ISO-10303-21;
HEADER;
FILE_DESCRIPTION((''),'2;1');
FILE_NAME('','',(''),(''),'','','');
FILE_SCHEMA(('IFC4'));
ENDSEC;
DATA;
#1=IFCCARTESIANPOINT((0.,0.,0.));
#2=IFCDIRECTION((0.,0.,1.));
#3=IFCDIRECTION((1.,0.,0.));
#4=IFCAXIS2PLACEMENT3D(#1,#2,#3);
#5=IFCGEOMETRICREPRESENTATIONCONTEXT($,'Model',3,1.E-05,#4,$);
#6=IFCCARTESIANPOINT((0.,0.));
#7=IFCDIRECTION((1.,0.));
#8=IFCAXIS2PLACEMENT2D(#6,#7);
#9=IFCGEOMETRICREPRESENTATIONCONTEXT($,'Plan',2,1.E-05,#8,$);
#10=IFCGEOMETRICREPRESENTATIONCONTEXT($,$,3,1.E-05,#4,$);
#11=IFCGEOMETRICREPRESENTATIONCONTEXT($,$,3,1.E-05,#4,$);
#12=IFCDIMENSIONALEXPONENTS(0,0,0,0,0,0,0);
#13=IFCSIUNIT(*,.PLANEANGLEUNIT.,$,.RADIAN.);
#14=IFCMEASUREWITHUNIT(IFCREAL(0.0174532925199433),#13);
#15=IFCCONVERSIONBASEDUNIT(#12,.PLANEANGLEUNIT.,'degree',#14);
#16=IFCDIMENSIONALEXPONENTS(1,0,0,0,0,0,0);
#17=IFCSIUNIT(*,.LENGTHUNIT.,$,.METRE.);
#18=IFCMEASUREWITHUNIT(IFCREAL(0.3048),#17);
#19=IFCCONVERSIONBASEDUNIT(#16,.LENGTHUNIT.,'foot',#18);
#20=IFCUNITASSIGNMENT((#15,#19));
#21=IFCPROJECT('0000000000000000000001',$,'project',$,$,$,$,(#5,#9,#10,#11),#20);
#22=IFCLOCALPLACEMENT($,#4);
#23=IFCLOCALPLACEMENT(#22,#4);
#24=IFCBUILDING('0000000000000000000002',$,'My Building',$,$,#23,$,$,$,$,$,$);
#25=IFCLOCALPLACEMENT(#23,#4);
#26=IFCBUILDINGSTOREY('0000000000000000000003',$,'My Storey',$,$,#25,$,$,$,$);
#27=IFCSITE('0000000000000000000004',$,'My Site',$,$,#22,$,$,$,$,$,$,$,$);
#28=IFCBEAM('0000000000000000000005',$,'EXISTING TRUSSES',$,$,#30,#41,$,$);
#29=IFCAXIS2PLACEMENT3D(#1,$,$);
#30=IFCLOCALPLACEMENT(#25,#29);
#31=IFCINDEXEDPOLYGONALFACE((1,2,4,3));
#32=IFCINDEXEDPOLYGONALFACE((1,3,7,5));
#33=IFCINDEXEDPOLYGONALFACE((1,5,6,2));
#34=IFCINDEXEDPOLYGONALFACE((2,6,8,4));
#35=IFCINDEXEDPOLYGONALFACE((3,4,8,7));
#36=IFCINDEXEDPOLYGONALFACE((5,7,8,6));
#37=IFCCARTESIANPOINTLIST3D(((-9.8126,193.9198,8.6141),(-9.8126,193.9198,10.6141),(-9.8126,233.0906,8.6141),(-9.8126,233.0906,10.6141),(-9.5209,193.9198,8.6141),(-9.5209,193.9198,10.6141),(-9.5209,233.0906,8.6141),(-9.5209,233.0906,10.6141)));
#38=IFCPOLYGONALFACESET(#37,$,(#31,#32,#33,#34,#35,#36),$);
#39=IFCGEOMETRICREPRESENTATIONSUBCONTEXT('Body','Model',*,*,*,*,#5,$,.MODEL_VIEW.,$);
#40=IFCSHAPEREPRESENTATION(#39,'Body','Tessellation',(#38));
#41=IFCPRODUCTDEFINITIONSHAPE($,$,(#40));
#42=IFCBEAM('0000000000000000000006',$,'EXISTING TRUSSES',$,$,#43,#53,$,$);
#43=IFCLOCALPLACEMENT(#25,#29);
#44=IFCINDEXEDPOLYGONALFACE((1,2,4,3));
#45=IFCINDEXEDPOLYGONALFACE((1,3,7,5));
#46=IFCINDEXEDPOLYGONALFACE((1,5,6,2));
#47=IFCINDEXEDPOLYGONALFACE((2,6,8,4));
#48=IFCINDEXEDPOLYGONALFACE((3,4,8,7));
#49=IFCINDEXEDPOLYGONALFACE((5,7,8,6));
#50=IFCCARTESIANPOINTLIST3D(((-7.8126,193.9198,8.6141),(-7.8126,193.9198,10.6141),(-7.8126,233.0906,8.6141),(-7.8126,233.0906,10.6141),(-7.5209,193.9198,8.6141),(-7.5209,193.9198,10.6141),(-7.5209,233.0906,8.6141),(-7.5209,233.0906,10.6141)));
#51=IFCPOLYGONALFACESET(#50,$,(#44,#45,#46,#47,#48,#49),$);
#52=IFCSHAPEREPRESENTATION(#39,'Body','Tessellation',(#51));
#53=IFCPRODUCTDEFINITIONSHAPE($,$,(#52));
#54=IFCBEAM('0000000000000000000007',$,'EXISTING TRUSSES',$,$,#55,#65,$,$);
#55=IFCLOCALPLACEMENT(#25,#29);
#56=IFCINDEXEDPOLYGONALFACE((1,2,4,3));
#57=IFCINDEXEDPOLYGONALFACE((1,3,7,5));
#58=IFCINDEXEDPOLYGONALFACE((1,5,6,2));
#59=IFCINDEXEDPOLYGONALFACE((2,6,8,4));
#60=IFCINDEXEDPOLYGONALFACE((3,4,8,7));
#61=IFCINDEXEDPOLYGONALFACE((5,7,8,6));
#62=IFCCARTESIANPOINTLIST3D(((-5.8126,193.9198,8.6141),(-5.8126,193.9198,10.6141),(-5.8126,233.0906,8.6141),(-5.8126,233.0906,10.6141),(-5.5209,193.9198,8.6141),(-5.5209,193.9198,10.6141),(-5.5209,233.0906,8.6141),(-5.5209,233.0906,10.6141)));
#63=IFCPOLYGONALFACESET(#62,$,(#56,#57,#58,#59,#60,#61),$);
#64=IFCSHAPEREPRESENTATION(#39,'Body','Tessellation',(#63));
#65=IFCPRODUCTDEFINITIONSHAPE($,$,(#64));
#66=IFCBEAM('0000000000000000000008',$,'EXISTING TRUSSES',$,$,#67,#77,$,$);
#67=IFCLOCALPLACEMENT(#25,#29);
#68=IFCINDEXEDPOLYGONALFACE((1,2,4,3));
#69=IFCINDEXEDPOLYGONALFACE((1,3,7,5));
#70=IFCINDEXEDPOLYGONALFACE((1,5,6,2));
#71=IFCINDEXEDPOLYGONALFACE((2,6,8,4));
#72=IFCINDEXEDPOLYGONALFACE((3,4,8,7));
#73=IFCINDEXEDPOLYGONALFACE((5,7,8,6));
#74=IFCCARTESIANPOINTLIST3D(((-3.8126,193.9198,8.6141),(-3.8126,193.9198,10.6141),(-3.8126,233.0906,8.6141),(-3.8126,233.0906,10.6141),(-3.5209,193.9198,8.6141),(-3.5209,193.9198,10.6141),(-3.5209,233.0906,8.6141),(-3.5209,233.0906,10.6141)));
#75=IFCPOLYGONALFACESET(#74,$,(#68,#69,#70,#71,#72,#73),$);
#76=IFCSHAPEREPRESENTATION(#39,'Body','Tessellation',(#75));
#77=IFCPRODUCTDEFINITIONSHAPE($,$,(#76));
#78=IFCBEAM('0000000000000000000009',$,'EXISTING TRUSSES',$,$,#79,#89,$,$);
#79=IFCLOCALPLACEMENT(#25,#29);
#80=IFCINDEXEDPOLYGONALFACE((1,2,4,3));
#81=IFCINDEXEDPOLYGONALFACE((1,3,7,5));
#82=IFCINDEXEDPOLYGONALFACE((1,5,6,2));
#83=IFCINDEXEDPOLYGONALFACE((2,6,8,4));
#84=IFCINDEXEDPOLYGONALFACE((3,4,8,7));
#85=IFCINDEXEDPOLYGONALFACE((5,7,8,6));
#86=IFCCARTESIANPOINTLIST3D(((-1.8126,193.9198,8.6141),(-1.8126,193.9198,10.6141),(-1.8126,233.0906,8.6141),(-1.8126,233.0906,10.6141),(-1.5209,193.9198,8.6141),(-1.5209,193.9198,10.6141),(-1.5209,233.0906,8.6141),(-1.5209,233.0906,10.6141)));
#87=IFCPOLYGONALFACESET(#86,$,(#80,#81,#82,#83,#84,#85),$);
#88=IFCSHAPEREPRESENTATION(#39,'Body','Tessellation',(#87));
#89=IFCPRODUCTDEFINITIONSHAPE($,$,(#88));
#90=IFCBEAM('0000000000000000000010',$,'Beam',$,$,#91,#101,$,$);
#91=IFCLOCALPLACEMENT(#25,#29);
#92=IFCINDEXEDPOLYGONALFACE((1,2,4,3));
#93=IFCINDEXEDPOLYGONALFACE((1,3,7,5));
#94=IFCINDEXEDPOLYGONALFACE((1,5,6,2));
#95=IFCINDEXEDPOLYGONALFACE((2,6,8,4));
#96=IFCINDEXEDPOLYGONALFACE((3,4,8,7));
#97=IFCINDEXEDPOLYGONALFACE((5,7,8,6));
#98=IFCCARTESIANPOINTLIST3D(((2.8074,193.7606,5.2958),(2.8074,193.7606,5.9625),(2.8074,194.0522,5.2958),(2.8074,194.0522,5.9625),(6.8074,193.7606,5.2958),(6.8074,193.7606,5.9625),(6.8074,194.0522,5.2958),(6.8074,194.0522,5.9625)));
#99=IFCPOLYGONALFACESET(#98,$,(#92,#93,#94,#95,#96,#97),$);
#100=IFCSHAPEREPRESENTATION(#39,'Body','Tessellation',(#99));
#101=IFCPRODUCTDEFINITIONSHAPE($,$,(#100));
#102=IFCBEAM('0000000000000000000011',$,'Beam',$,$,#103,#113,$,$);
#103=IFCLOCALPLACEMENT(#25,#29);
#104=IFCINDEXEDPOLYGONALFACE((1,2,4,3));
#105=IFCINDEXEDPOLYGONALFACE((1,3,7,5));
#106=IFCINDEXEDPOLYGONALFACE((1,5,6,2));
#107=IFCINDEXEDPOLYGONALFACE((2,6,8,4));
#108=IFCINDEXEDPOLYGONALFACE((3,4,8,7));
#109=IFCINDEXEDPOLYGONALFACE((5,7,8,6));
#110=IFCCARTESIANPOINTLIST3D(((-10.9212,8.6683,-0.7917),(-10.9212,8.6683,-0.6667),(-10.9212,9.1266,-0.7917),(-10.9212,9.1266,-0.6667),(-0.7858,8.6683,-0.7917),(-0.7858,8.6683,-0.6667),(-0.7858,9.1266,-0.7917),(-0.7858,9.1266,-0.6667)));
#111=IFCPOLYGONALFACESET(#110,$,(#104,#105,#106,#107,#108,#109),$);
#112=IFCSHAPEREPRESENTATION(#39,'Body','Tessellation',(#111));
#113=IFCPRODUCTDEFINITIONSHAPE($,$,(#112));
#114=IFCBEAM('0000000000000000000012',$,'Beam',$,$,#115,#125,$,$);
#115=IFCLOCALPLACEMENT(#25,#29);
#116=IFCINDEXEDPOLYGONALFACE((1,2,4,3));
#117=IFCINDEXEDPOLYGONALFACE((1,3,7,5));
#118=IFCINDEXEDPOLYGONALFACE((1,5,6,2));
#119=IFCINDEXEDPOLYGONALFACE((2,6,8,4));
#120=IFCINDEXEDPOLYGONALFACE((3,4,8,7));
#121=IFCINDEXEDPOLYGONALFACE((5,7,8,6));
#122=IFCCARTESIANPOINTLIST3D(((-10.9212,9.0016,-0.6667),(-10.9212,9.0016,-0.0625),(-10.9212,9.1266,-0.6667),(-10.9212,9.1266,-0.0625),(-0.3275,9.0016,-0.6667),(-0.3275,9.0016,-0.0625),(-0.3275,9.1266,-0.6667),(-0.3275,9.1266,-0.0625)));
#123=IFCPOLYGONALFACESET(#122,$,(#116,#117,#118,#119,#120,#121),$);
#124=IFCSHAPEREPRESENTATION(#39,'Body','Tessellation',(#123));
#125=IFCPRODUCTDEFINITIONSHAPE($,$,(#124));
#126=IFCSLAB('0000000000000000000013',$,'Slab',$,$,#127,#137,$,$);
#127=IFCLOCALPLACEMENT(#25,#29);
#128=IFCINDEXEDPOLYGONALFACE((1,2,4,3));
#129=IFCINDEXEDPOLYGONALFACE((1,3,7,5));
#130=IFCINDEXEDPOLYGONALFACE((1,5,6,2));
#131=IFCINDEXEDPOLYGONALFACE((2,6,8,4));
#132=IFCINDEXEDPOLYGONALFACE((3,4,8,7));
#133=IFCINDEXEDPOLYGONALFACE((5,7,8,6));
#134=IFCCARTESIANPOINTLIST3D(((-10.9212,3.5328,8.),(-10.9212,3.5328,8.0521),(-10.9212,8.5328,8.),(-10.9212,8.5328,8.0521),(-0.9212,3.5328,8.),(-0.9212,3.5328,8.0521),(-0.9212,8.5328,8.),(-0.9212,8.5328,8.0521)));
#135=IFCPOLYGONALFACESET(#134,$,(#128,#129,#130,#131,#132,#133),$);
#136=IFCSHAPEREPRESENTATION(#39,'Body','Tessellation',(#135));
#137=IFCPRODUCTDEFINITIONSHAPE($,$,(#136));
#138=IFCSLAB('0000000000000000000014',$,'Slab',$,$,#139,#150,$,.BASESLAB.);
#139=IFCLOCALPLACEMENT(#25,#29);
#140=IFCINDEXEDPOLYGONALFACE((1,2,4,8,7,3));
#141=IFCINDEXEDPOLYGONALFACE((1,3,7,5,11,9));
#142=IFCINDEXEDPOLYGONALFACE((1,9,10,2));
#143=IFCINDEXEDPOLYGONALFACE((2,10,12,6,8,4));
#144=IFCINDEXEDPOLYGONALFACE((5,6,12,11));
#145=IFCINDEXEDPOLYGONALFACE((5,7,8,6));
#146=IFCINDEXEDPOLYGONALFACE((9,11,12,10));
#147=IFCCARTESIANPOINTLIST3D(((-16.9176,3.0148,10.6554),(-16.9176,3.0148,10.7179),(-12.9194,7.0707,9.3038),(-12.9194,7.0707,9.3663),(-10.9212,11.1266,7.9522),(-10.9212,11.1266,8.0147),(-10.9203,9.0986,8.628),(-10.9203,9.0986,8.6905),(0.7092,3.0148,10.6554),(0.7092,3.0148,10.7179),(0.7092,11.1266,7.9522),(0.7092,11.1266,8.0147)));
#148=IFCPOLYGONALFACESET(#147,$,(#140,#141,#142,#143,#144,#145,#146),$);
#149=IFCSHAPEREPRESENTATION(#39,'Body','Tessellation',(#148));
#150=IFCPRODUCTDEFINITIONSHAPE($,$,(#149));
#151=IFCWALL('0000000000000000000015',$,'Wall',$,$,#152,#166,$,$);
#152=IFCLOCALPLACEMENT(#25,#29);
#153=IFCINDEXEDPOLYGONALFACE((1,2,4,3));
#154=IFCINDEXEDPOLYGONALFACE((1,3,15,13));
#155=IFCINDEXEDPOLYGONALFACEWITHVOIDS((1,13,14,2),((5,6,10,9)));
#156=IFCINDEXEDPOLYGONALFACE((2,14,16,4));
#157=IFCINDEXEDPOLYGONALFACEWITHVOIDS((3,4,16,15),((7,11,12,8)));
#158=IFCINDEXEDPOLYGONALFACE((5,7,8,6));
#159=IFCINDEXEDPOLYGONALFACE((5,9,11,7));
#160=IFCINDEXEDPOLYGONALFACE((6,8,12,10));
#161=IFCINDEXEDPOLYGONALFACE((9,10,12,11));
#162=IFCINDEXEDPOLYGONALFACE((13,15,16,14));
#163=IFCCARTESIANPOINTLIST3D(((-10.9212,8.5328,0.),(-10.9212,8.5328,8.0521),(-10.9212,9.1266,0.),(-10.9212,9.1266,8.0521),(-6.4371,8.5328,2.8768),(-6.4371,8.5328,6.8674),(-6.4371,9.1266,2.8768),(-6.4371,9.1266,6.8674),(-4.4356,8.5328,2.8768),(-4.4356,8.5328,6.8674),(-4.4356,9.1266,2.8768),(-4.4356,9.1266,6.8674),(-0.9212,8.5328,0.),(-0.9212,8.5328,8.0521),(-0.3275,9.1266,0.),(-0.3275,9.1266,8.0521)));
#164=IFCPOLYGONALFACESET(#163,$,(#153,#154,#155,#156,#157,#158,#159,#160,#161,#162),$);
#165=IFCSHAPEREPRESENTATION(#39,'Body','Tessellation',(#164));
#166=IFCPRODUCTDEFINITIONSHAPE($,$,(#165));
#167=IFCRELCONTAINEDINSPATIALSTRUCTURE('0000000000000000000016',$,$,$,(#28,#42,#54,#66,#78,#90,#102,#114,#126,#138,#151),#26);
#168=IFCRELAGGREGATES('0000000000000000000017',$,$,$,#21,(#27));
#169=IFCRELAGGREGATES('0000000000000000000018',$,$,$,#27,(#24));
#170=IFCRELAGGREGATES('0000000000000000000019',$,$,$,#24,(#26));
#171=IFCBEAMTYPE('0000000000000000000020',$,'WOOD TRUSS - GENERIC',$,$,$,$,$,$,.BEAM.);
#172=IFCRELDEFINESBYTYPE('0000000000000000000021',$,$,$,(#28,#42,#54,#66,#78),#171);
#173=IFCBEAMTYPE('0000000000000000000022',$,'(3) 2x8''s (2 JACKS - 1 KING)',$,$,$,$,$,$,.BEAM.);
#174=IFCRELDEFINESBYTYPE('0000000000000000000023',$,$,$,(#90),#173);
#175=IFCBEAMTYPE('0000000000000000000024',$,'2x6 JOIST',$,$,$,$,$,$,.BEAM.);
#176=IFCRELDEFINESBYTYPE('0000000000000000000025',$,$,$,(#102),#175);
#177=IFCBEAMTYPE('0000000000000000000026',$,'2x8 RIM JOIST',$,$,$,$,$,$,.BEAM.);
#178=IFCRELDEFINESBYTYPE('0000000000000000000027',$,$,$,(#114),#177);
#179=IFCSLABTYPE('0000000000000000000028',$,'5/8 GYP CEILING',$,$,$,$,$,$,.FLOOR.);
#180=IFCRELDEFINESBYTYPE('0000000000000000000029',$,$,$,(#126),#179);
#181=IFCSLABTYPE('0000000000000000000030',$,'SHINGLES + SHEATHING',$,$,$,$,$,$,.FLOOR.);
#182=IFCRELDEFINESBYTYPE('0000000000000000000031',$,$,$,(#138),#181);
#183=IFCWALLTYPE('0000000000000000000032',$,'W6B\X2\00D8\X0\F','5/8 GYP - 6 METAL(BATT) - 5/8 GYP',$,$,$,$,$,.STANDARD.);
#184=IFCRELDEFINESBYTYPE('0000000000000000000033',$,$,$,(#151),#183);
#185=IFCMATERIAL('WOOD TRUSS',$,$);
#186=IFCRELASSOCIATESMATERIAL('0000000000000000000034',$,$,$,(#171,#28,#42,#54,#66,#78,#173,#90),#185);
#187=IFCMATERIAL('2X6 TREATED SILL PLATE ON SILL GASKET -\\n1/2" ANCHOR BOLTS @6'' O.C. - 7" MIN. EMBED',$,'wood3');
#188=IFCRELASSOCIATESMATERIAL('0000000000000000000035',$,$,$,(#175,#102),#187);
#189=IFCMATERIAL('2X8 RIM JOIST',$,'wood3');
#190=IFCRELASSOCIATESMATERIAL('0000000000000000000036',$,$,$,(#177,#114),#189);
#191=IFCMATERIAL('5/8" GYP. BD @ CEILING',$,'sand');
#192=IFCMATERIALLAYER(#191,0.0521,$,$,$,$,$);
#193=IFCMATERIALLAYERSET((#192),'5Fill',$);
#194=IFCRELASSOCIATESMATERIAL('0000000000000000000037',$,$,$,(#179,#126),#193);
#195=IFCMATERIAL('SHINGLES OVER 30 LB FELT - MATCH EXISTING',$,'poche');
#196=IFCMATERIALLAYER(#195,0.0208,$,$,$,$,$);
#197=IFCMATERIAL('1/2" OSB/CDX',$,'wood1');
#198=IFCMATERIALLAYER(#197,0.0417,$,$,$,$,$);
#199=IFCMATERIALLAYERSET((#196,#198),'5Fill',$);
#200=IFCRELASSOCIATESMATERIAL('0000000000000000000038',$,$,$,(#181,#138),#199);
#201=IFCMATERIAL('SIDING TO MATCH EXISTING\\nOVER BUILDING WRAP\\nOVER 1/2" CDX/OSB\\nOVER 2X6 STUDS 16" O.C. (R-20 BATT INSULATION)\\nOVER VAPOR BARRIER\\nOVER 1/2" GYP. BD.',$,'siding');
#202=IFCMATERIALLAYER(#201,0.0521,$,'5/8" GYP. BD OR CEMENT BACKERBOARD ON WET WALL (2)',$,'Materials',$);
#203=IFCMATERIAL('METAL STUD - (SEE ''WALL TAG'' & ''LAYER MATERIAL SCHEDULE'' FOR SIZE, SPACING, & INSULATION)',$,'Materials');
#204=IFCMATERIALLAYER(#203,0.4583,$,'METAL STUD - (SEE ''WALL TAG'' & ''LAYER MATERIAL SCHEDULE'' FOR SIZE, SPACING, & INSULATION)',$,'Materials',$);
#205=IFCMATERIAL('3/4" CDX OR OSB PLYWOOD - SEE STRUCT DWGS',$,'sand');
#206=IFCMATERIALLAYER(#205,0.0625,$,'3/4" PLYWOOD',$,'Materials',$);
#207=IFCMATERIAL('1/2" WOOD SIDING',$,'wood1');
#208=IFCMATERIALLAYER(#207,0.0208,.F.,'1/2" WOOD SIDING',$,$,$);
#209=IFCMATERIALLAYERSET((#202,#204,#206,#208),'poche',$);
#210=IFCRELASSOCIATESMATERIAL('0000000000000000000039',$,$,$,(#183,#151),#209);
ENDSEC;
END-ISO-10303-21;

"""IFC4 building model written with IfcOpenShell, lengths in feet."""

from ifc_helpers import new_model, entity, si_unit, converted_unit, frame, origin_with_axes, origin_2d_with_axis, place, context, subcontext, project, spatial, line, indexed_curve, rectangle, outline, extrude, clip, halfspace, source, transform, mapped, material, layer, layer_set, layer_usage, material_profile, profile_set, profile_usage, type_object, element, save


model = new_model("IFC4")

# Units and contexts
model_context = context("Model", 3, precision=1e-05, world=origin_with_axes())
plan_context = context("Plan", 2, precision=1e-05, world=origin_2d_with_axis())
context_of_model_1 = context(None, 3, precision=1e-05, world=origin_with_axes())
context_of_model_2 = context(None, 3, precision=1e-05, world=origin_with_axes())
body_context = subcontext(model_context, "Body", "Model", "MODEL_VIEW")
ifc_project = project(units=[converted_unit("PLANEANGLEUNIT", "degree", entity("IfcReal", 0.0174532925199433), si_unit("PLANEANGLEUNIT", "RADIAN"), dimensions=[0, 0, 0, 0, 0, 0, 0]), converted_unit("LENGTHUNIT", "foot", entity("IfcReal", 0.3048), si_unit("LENGTHUNIT", "METRE"), dimensions=[1, 0, 0, 0, 0, 0, 0])], contexts=[model_context, plan_context, context_of_model_1, context_of_model_2])

# Site, building, storey
site_placement = place(None, origin_with_axes())
site = spatial("IfcSite", under=ifc_project, at=site_placement, Name="My Site")
building_placement = place(site_placement, origin_with_axes())
building = spatial("IfcBuilding", under=site, at=building_placement, Name="My Building")
storey_placement = place(building_placement, origin_with_axes())
storey = spatial("IfcBuildingStorey", under=building, at=storey_placement, Name="My Storey")

# Beams
ifc_material_1 = material(Name="WOOD TRUSS")
ifc_material_profile_1 = material_profile(ifc_material_1, rectangle(XDim=0.2917, YDim=2.0))
ifc_profile_set_1 = profile_set([ifc_material_profile_1])
ifc_profile_usage_1 = profile_usage(ifc_profile_set_1, cardinal=5)
beam_type_1 = type_object("IfcBeamType", Name="WOOD TRUSS - GENERIC", PredefinedType="BEAM", material=ifc_profile_set_1)
beam_1_placement = place(storey_placement, frame((-9.6667, 193.9198, 9.6141), z_axis=(0.0, 1.0, 0.0), x_axis=(-1.0, 0.0, 0.0)))
element("IfcBeam", 1, at=beam_1_placement, inside=storey, type_object=beam_type_1, material=ifc_profile_usage_1, Name="EXISTING TRUSSES", context=body_context, shape_type="SweptSolid", body=[
    extrude(rectangle(XDim=0.2917, YDim=2.0), origin_with_axes(), (0.0, 0.0, 1.0), 39.1707),
])
ifc_profile_usage_2 = profile_usage(ifc_profile_set_1, cardinal=5)
beam_2_placement = place(storey_placement, frame((-7.6667, 193.9198, 9.6141), z_axis=(0.0, 1.0, 0.0), x_axis=(-1.0, 0.0, 0.0)))
element("IfcBeam", 2, at=beam_2_placement, inside=storey, type_object=beam_type_1, material=ifc_profile_usage_2, Name="EXISTING TRUSSES", context=body_context, shape_type="SweptSolid", body=[
    extrude(rectangle(XDim=0.2917, YDim=2.0), origin_with_axes(), (0.0, 0.0, 1.0), 39.1707),
])
ifc_profile_usage_3 = profile_usage(ifc_profile_set_1, cardinal=5)
beam_3_placement = place(storey_placement, frame((-5.6667, 193.9198, 9.6141), z_axis=(0.0, 1.0, 0.0), x_axis=(-1.0, 0.0, 0.0)))
element("IfcBeam", 3, at=beam_3_placement, inside=storey, type_object=beam_type_1, material=ifc_profile_usage_3, Name="EXISTING TRUSSES", context=body_context, shape_type="SweptSolid", body=[
    extrude(rectangle(XDim=0.2917, YDim=2.0), origin_with_axes(), (0.0, 0.0, 1.0), 39.1707),
])
ifc_profile_usage_4 = profile_usage(ifc_profile_set_1, cardinal=5)
beam_4_placement = place(storey_placement, frame((-3.6667, 193.9198, 9.6141), z_axis=(0.0, 1.0, 0.0), x_axis=(-1.0, 0.0, 0.0)))
element("IfcBeam", 4, at=beam_4_placement, inside=storey, type_object=beam_type_1, material=ifc_profile_usage_4, Name="EXISTING TRUSSES", context=body_context, shape_type="SweptSolid", body=[
    extrude(rectangle(XDim=0.2917, YDim=2.0), origin_with_axes(), (0.0, 0.0, 1.0), 39.1707),
])
ifc_profile_usage_5 = profile_usage(ifc_profile_set_1, cardinal=5)
beam_5_placement = place(storey_placement, frame((-1.6667, 193.9198, 9.6141), z_axis=(0.0, 1.0, 0.0), x_axis=(-1.0, 0.0, 0.0)))
element("IfcBeam", 5, at=beam_5_placement, inside=storey, type_object=beam_type_1, material=ifc_profile_usage_5, Name="EXISTING TRUSSES", context=body_context, shape_type="SweptSolid", body=[
    extrude(rectangle(XDim=0.2917, YDim=2.0), origin_with_axes(), (0.0, 0.0, 1.0), 39.1707),
])
ifc_material_profile_2 = material_profile(ifc_material_1, rectangle(XDim=0.2917, YDim=0.6667))
ifc_profile_set_2 = profile_set([ifc_material_profile_2])
ifc_profile_usage_6 = profile_usage(ifc_profile_set_2, cardinal=5)
beam_type_2 = type_object("IfcBeamType", Name="(3) 2x8's (2 JACKS - 1 KING)", PredefinedType="BEAM", material=ifc_profile_set_2)
beam_6_placement = place(storey_placement, frame((2.8074, 193.9064, 5.6292), z_axis=(1.0, 0.0, 0.0), x_axis=(0.0, 1.0, 0.0)))
element("IfcBeam", 6, at=beam_6_placement, inside=storey, type_object=beam_type_2, material=ifc_profile_usage_6, Name="Beam", context=body_context, shape_type="SweptSolid", body=[
    extrude(rectangle(XDim=0.2917, YDim=0.6667), origin_with_axes(), (0.0, 0.0, 1.0), 4.0),
])
ifc_material_2 = material(Name="2X6 TREATED SILL PLATE ON SILL GASKET -\\n1/2\" ANCHOR BOLTS @6' O.C. - 7\" MIN. EMBED", Category="wood3")
ifc_material_profile_3 = material_profile(ifc_material_2, rectangle(XDim=0.125, YDim=0.4583))
ifc_profile_set_3 = profile_set([ifc_material_profile_3])
ifc_profile_usage_7 = profile_usage(ifc_profile_set_3, cardinal=5)
beam_type_3 = type_object("IfcBeamType", Name="2x6 JOIST", PredefinedType="BEAM", material=ifc_profile_set_3)
beam_7_placement = place(storey_placement, frame((-10.9212, 8.8974, -0.7292), z_axis=(1.0, 0.0, 0.0), x_axis=(0.0, 0.0, 1.0)))
element("IfcBeam", 7, at=beam_7_placement, inside=storey, type_object=beam_type_3, material=ifc_profile_usage_7, Name="Beam", context=body_context, shape_type="SweptSolid", body=[
    extrude(rectangle(XDim=0.125, YDim=0.4583), origin_with_axes(), (0.0, 0.0, 1.0), 10.1354),
])
ifc_material_3 = material(Name="2X8 RIM JOIST", Category="wood3")
ifc_material_profile_4 = material_profile(ifc_material_3, rectangle(XDim=0.125, YDim=0.6042))
ifc_profile_set_4 = profile_set([ifc_material_profile_4])
ifc_profile_usage_8 = profile_usage(ifc_profile_set_4)
beam_type_4 = type_object("IfcBeamType", Name="2x8 RIM JOIST", PredefinedType="BEAM", material=ifc_profile_set_4)
beam_8_placement = place(storey_placement, frame((-10.9212, 9.0641, -0.3646), z_axis=(1.0, 0.0, 0.0), x_axis=(0.0, 1.0, 0.0)))
element("IfcBeam", 8, at=beam_8_placement, inside=storey, type_object=beam_type_4, material=ifc_profile_usage_8, Name="Beam", context=body_context, shape_type="SweptSolid", body=[
    extrude(rectangle(XDim=0.125, YDim=0.6042), origin_with_axes(), (0.0, 0.0, 1.0), 10.5937),
])

# Slabs
ifc_material_4 = material(Name="5/8\" GYP. BD @ CEILING", Category="sand")
ifc_layer_1 = layer(ifc_material_4, 0.0521)
ifc_layer_set_1 = layer_set([ifc_layer_1], Name="5Fill")
ifc_layer_usage_1 = layer_usage(ifc_layer_set_1, "AXIS3", "POSITIVE", 0.0)
slab_type_1 = type_object("IfcSlabType", Name="5/8 GYP CEILING", PredefinedType="FLOOR", material=ifc_layer_set_1)
slab_1_placement = place(storey_placement, frame((-10.9212, 3.5328, 8.0), z_axis=(0.0, 0.0, 1.0), x_axis=(1.0, 0.0, 0.0)))
element("IfcSlab", 9, at=slab_1_placement, inside=storey, type_object=slab_type_1, material=ifc_layer_usage_1, Name="Slab", context=body_context, shape_type="SweptSolid", body=[
    extrude(outline(indexed_curve([(10.0, 5.0), (10.0, 0.0), (0.0, 0.0), (0.0, 5.0)], segments=[line(3, 2), line(2, 1), line(1, 4), line(4, 3)], self_intersect=False)), None, (0.0, 0.0, 1.0), 0.0521),
])
ifc_material_5 = material(Name="SHINGLES OVER 30 LB FELT - MATCH EXISTING", Category="poche")
ifc_layer_2 = layer(ifc_material_5, 0.0208)
ifc_material_6 = material(Name="1/2\" OSB/CDX", Category="wood1")
ifc_layer_3 = layer(ifc_material_6, 0.0417)
ifc_layer_set_2 = layer_set([ifc_layer_2, ifc_layer_3], Name="5Fill")
ifc_layer_usage_2 = layer_usage(ifc_layer_set_2, "AXIS3", "POSITIVE", 0.0)
slab_type_2 = type_object("IfcSlabType", Name="SHINGLES + SHEATHING", PredefinedType="FLOOR", material=ifc_layer_set_2)
slab_2_placement = place(storey_placement, frame((0.7092, 11.1266, 7.9522), z_axis=(0.0, 0.316146, 0.948711), x_axis=(-1.0, 0.0, 0.0)))
element("IfcSlab", 10, at=slab_2_placement, inside=storey, type_object=slab_type_2, material=ifc_layer_usage_2, Name="Slab", PredefinedType="BASESLAB", context=body_context, shape_type="SweptSolid", body=[
    extrude(outline(indexed_curve([(17.6268, 8.5503), (11.6304, 0.0), (0.0, 0.0), (0.0, 8.5503), (13.6286, 4.2752), (11.6295, 2.1376)], segments=[line(5, 1), line(1, 4), line(4, 3), line(3, 2), line(2, 6), line(6, 5)], self_intersect=False)), None, (0.0, 0.316146, 0.948711), 0.0625),
])

# Wall, opening
ifc_material_7 = material(Name="SIDING TO MATCH EXISTING\\nOVER BUILDING WRAP\\nOVER 1/2\" CDX/OSB\\nOVER 2X6 STUDS 16\" O.C. (R-20 BATT INSULATION)\\nOVER VAPOR BARRIER\\nOVER 1/2\" GYP. BD.", Category="siding")
ifc_layer_4 = layer(ifc_material_7, 0.0521, Name="5/8\" GYP. BD OR CEMENT BACKERBOARD ON WET WALL (2)", Category="Materials")
ifc_material_8 = material(Name="METAL STUD - (SEE 'WALL TAG' & 'LAYER MATERIAL SCHEDULE' FOR SIZE, SPACING, & INSULATION)", Category="Materials")
ifc_layer_5 = layer(ifc_material_8, 0.4583, Name="METAL STUD - (SEE 'WALL TAG' & 'LAYER MATERIAL SCHEDULE' FOR SIZE, SPACING, & INSULATION)", Category="Materials")
ifc_material_9 = material(Name="3/4\" CDX OR OSB PLYWOOD - SEE STRUCT DWGS", Category="sand")
ifc_layer_6 = layer(ifc_material_9, 0.0625, Name="3/4\" PLYWOOD", Category="Materials")
ifc_material_10 = material(Name="1/2\" WOOD SIDING", Category="wood1")
ifc_layer_7 = layer(ifc_material_10, 0.0208, ventilated=False, Name="1/2\" WOOD SIDING")
ifc_layer_set_3 = layer_set([ifc_layer_4, ifc_layer_5, ifc_layer_6, ifc_layer_7], Name="poche")
ifc_layer_usage_3 = layer_usage(ifc_layer_set_3, "AXIS2", "POSITIVE", 0.0)
wall_type_1 = type_object("IfcWallType", Name="W6BØF", Description="5/8 GYP - 6 METAL(BATT) - 5/8 GYP", PredefinedType="STANDARD", material=ifc_layer_set_3)
wall_1_placement = place(storey_placement, frame((-10.9212, 8.5328, 0.0), z_axis=(0.0, 0.0, 1.0), x_axis=(1.0, 0.0, 0.0)))
wall_1 = element("IfcWall", 11, at=wall_1_placement, inside=storey, type_object=wall_type_1, material=ifc_layer_usage_3, Name="Wall", context=body_context, shape_type="Clipping", body=[
    clip(extrude(outline(indexed_curve([(0.0, 0.0), (0.0, 0.5937), (10.5938, 0.5937), (10.5938, 0.0), (0.0, 0.0)], self_intersect=False)), origin_with_axes(), (0.0, 0.0, 1.0), 8.0521), halfspace(frame((10.0, 0.0, 0.0), z_axis=(0.707107, -0.707107, 0.0), x_axis=(-0.707107, -0.707107, 0.0)), False)),
])
shared_shape_1 = source(origin_with_axes(), body_context, "Body", "SweptSolid", [
    extrude(outline(indexed_curve([(0.0, 0.0), (2.0015, 0.0), (2.0015, 3.9906), (0.0, 3.9906)], segments=[line(1, 2, 3, 4, 1)])), frame((0.0, -1.9685, 0.0), z_axis=(0.0, -1.0, 0.0), x_axis=(1.0, 0.0, 0.0)), (0.0, 0.0, -1.0), 3.937),
])
opening_1_placement = place(wall_1_placement, frame((4.4841, 0.2128, 2.8768), z_axis=(0.0, 0.0, 1.0), x_axis=(1.0, 0.0, 0.0)))
element("IfcOpeningElement", 12, at=opening_1_placement, cuts=wall_1, PredefinedType="OPENING", context=body_context, shape_type="MappedRepresentation", body=[
    mapped(shared_shape_1, transform((0.0, 0.0, 0.0), x_axis=(1.0, 0.0, 0.0), y_axis=(0.0, 1.0, 0.0), z_axis=(0.0, 0.0, 1.0), scale=1.0)),
])

save(model, "model.ifc")
